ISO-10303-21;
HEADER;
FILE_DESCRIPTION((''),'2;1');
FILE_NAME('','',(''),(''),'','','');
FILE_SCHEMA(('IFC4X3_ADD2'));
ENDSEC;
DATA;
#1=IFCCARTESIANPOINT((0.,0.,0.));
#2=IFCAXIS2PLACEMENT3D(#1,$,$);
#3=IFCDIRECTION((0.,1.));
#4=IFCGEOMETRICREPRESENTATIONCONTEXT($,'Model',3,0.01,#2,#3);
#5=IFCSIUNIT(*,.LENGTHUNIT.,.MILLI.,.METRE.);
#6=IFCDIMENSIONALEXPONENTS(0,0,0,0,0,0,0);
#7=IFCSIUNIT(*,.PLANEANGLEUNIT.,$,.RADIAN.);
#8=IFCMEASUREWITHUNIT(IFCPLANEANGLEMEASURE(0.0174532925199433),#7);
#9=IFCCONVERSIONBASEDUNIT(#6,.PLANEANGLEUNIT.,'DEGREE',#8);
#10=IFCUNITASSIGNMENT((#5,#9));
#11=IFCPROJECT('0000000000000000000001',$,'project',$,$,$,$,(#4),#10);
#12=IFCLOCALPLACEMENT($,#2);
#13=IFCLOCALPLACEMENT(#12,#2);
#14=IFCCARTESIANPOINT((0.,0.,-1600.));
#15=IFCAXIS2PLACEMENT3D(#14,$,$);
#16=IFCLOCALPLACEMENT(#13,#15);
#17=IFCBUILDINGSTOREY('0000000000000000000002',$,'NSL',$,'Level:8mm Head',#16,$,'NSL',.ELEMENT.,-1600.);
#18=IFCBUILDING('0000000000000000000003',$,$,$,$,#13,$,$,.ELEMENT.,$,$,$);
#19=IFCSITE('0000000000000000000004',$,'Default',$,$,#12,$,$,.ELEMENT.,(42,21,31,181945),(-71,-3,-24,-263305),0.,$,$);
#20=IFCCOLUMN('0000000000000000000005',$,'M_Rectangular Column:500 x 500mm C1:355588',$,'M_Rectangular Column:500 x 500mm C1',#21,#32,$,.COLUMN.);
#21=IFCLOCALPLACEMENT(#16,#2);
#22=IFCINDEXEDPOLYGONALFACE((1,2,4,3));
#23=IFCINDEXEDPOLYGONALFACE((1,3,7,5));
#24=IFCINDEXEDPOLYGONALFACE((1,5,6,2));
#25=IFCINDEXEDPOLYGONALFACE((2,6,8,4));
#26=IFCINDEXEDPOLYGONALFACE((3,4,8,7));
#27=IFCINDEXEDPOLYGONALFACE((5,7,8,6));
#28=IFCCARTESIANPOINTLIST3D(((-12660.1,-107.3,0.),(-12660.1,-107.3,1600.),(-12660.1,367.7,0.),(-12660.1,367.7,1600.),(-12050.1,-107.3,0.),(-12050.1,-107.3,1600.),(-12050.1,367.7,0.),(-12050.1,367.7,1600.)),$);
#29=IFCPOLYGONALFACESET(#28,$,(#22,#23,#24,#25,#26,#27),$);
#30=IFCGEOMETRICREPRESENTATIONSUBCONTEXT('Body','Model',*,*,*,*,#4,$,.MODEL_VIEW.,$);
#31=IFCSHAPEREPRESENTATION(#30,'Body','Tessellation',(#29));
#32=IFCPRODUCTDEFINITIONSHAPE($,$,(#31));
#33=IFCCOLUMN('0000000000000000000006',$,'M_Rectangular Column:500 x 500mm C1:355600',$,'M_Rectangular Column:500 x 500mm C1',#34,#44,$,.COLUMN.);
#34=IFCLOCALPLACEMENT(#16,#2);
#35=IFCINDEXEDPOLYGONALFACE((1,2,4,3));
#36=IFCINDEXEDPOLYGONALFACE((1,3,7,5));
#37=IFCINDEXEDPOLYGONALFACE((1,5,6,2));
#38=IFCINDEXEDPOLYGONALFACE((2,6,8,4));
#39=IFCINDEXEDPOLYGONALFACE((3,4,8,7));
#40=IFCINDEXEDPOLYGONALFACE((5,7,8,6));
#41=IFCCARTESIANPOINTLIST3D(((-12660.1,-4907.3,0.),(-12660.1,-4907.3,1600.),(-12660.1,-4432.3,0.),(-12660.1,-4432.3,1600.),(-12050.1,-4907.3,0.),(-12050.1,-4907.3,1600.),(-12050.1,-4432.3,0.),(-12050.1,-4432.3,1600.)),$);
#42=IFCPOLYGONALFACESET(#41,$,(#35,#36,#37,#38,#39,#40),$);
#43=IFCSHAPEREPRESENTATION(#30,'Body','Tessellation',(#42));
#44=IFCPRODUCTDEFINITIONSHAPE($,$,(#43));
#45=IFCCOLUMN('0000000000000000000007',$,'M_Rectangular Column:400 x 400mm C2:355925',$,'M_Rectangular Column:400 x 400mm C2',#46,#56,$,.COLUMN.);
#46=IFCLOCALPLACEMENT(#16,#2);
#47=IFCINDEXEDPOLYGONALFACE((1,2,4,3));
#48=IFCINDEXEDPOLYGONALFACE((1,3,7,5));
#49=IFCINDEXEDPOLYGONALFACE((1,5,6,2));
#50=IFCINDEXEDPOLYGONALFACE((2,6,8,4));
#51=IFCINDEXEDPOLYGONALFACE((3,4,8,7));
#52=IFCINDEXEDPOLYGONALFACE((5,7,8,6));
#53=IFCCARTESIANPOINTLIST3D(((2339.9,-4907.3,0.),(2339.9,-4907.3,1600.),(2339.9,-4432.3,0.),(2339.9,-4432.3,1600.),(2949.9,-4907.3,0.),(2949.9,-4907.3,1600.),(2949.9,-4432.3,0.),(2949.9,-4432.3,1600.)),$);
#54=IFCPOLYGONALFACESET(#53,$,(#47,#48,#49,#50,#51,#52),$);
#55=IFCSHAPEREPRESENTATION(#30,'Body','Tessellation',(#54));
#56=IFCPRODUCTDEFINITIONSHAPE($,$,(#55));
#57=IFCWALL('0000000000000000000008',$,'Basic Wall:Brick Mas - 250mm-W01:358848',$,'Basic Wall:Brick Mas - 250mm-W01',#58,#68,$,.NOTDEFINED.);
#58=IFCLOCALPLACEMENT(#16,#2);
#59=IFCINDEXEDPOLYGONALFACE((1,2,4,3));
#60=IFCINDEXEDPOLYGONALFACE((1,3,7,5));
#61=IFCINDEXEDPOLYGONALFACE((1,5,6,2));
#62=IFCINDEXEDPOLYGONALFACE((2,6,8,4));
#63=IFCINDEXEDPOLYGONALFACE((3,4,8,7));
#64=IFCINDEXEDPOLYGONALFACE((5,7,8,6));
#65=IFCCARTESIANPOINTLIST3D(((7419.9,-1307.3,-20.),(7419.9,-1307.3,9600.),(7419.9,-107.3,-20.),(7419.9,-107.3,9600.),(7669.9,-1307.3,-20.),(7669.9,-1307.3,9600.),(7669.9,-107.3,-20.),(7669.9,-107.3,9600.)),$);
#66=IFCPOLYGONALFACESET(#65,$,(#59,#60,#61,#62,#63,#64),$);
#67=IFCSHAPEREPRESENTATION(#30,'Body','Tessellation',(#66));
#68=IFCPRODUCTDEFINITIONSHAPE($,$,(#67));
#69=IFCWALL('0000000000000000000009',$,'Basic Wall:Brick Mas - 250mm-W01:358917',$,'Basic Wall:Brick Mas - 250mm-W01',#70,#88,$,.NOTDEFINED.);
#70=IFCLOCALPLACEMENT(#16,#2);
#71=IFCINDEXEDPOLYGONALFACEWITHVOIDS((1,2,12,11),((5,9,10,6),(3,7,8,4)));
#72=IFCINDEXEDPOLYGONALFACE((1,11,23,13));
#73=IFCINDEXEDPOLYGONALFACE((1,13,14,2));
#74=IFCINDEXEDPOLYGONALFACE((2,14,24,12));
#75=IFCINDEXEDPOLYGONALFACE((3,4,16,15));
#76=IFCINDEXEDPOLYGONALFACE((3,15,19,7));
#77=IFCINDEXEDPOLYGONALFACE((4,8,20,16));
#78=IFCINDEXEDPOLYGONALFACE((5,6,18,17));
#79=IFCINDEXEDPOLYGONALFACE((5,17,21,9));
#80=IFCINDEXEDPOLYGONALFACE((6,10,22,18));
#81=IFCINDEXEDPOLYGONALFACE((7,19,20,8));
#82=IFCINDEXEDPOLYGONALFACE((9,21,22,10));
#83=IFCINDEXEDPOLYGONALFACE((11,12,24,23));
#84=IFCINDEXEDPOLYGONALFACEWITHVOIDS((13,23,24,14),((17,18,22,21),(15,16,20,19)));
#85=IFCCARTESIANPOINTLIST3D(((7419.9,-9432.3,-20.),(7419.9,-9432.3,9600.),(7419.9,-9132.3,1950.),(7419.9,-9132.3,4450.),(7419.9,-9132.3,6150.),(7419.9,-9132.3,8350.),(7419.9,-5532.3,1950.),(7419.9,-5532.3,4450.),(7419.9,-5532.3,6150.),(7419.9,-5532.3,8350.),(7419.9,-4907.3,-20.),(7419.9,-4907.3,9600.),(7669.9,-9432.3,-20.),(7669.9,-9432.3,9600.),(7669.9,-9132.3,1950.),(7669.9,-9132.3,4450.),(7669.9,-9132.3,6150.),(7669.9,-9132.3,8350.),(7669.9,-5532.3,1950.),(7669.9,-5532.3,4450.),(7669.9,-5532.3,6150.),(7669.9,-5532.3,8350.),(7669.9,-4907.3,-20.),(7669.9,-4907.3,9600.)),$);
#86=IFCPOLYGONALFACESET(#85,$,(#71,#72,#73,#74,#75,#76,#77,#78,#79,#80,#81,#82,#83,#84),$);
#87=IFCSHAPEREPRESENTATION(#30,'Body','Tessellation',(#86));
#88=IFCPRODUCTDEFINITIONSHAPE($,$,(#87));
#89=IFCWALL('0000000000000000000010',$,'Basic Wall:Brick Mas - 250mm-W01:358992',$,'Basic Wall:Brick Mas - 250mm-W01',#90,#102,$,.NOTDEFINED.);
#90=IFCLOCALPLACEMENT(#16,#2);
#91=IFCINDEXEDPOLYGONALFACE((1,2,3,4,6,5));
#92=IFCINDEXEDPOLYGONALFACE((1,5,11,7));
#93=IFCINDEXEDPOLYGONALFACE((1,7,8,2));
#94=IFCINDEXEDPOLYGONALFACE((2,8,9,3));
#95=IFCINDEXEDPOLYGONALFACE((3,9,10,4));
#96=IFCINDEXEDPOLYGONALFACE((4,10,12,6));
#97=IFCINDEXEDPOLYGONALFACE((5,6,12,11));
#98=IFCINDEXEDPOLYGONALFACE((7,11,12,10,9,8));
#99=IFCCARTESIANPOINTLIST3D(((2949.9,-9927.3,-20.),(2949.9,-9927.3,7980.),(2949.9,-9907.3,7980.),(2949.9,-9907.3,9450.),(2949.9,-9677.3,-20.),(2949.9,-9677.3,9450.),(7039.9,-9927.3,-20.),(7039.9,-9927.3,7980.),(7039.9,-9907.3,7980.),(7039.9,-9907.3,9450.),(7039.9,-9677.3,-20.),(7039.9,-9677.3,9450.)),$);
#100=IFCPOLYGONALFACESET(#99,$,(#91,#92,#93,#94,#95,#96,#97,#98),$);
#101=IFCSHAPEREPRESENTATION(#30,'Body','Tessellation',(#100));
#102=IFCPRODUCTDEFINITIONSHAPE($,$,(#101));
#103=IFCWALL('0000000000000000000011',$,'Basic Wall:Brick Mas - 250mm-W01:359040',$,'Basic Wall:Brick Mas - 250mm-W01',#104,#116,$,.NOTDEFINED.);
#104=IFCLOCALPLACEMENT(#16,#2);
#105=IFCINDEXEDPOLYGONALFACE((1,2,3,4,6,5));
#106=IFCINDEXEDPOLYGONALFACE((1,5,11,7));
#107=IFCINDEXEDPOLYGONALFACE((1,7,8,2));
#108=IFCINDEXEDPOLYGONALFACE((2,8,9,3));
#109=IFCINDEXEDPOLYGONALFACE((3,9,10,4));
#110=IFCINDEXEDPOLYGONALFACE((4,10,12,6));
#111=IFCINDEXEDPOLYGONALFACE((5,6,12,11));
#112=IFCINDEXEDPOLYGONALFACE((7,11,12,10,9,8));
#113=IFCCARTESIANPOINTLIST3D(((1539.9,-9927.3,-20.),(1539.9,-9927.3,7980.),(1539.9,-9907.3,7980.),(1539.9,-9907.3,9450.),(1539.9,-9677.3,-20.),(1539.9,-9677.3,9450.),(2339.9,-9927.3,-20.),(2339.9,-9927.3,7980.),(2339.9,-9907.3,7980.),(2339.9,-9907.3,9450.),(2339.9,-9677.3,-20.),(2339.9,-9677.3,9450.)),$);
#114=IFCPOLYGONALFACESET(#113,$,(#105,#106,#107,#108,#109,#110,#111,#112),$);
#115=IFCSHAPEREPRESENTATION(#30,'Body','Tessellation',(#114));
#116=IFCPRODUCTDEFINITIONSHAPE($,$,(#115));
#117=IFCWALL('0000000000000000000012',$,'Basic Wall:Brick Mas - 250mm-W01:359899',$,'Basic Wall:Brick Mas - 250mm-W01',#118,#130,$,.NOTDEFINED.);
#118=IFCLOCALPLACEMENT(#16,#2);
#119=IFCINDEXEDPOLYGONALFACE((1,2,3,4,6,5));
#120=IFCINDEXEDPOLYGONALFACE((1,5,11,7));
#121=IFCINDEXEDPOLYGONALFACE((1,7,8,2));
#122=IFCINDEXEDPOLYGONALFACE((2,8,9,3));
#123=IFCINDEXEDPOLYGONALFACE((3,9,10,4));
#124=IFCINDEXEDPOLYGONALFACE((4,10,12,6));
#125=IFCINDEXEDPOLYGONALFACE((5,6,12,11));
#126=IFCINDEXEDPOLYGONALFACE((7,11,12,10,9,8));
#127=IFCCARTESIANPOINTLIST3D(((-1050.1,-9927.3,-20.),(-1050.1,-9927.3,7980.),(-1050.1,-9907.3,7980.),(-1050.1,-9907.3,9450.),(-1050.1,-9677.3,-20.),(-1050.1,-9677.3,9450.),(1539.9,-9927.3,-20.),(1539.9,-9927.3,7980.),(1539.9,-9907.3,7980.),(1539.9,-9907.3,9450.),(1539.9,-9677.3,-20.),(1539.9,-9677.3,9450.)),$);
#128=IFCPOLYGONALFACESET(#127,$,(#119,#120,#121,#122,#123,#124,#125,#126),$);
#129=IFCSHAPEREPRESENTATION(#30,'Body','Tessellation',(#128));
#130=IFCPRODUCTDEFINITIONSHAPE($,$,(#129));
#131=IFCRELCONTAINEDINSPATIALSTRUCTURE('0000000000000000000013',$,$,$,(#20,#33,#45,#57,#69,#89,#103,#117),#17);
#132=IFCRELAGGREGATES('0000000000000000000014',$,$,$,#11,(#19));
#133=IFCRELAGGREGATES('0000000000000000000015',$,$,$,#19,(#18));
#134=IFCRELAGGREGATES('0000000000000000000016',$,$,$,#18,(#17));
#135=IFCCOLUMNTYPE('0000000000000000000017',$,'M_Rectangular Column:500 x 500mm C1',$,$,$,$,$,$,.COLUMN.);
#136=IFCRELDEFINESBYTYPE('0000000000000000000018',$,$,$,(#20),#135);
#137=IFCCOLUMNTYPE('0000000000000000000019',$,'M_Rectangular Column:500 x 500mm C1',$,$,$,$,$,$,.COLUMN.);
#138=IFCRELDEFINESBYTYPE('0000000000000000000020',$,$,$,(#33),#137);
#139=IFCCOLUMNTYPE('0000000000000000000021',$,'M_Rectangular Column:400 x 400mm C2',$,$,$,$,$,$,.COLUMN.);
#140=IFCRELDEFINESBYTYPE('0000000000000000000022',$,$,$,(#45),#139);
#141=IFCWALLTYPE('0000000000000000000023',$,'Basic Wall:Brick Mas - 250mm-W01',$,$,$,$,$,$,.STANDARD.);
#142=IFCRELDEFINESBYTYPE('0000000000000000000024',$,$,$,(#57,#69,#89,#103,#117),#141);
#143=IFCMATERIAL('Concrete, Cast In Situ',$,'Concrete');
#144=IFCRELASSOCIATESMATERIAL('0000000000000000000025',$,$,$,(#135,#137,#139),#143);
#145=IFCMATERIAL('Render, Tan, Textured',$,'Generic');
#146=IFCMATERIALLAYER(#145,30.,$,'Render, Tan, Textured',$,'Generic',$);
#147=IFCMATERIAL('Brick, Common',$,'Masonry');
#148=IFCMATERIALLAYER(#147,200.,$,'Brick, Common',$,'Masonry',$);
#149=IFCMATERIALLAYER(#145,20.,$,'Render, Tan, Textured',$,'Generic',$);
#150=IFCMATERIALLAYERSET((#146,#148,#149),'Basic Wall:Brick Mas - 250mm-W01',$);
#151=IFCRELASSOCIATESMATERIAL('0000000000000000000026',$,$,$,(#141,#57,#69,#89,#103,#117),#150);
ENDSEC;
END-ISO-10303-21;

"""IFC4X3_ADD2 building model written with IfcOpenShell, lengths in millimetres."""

from ifc_helpers import new_model, entity, si_unit, converted_unit, direction, frame, frame_2d, origin, origin_2d_with_axis, place, context, subcontext, project, spatial, polyline, rectangle, extrude, clip, bounded_halfspace, source, transform, mapped, material, layer, layer_set, material_profile, profile_set, type_object, type_shapes, element, save


model = new_model("IFC4X3_ADD2")

# Units and contexts
model_context = context("Model", 3, precision=0.01, world=origin(), true_north=direction((0.0, 1.0)))
body_context = subcontext(model_context, "Body", "Model", "MODEL_VIEW")
ifc_project = project(units=[si_unit("LENGTHUNIT", "METRE", prefix="MILLI"), converted_unit("PLANEANGLEUNIT", "DEGREE", entity("IfcPlaneAngleMeasure", 0.0174532925199433), si_unit("PLANEANGLEUNIT", "RADIAN"), dimensions=[0, 0, 0, 0, 0, 0, 0])], contexts=[model_context])

# Site, building, storey
site_placement = place(None, origin())
site = spatial("IfcSite", under=ifc_project, at=site_placement, Name="Default", CompositionType="ELEMENT", RefLatitude=(42, 21, 31, 181945), RefLongitude=(-71, -3, -24, -263305), RefElevation=0.0)
building_placement = place(site_placement, origin())
building = spatial("IfcBuilding", under=site, at=building_placement, CompositionType="ELEMENT")
storey_placement = place(building_placement, frame((0.0, 0.0, -1600.0)))
storey = spatial("IfcBuildingStorey", under=building, at=storey_placement, Name="NSL", ObjectType="Level:8mm Head", LongName="NSL", CompositionType="ELEMENT", Elevation=-1600.0)

# Columns
ifc_material_1 = material(Name="Concrete, Cast In Situ", Category="Concrete")
ifc_material_profile_1 = material_profile(ifc_material_1, rectangle(XDim=610.0, YDim=475.0, at=frame_2d((0.0, 0.0), x_axis=(1.0, 0.0))), Name="500 x 500mm C1")
ifc_profile_set_1 = profile_set([ifc_material_profile_1], Name="500 x 500mm C1")
column_type_1 = type_object("IfcColumnType", Name="M_Rectangular Column:500 x 500mm C1", PredefinedType="COLUMN", material=ifc_profile_set_1)
shared_shape_1 = source(origin(), body_context, "Body", "SweptSolid", [
    extrude(rectangle(XDim=610.0, YDim=475.0, at=origin_2d_with_axis()), frame((-12355.1, 130.2, -1600.0), z_axis=(0.0, 0.0, 1.0), x_axis=(-1.0, 0.0, 0.0)), (0.0, 0.0, 1.0), 1600.0),
])
type_shapes(column_type_1, [shared_shape_1])
column_1_placement = place(storey_placement, frame((0.0, 0.0, 1600.0)))
element("IfcColumn", 1, at=column_1_placement, inside=storey, type_object=column_type_1, Name="M_Rectangular Column:500 x 500mm C1:355588", ObjectType="M_Rectangular Column:500 x 500mm C1", PredefinedType="COLUMN", context=body_context, shape_type="MappedRepresentation", body=[
    mapped(shared_shape_1, transform((0.0, 0.0, 0.0), scale=1.0)),
])
column_type_2 = type_object("IfcColumnType", Name="M_Rectangular Column:500 x 500mm C1", PredefinedType="COLUMN", material=ifc_profile_set_1)
shared_shape_2 = source(origin(), body_context, "Body", "SweptSolid", [
    extrude(rectangle(XDim=610.0, YDim=475.0, at=frame_2d((0.0, 0.0), x_axis=(1.0, 0.0))), frame((-12355.1, -4669.8, -1600.0), z_axis=(0.0, 0.0, 1.0), x_axis=(-1.0, 0.0, 0.0)), (0.0, 0.0, 1.0), 1600.0),
])
type_shapes(column_type_2, [shared_shape_2])
column_2_placement = place(storey_placement, frame((0.0, 0.0, 1600.0)))
element("IfcColumn", 2, at=column_2_placement, inside=storey, type_object=column_type_2, Name="M_Rectangular Column:500 x 500mm C1:355600", ObjectType="M_Rectangular Column:500 x 500mm C1", PredefinedType="COLUMN", context=body_context, shape_type="MappedRepresentation", body=[
    mapped(shared_shape_2, transform((0.0, 0.0, 0.0), scale=1.0)),
])
ifc_material_profile_2 = material_profile(ifc_material_1, rectangle(XDim=610.0, YDim=475.0, at=origin_2d_with_axis()), Name="400 x 400mm C2")
ifc_profile_set_2 = profile_set([ifc_material_profile_2], Name="400 x 400mm C2")
column_type_3 = type_object("IfcColumnType", Name="M_Rectangular Column:400 x 400mm C2", PredefinedType="COLUMN", material=ifc_profile_set_2)
shared_shape_3 = source(origin(), body_context, "Body", "SweptSolid", [
    extrude(rectangle(XDim=610.0, YDim=475.0, at=origin_2d_with_axis()), frame((0.0, 0.0, -1600.0), z_axis=(0.0, 0.0, 1.0), x_axis=(-1.0, 0.0, 0.0)), (0.0, 0.0, 1.0), 1600.0),
])
type_shapes(column_type_3, [shared_shape_3])
column_3_placement = place(storey_placement, frame((2644.9, -4669.8, 1600.0)))
element("IfcColumn", 3, at=column_3_placement, inside=storey, type_object=column_type_3, Name="M_Rectangular Column:400 x 400mm C2:355925", ObjectType="M_Rectangular Column:400 x 400mm C2", PredefinedType="COLUMN", context=body_context, shape_type="MappedRepresentation", body=[
    mapped(shared_shape_3, transform((0.0, 0.0, 0.0), scale=1.0)),
])

# Wall
ifc_material_2 = material(Name="Render, Tan, Textured", Category="Generic")
ifc_layer_1 = layer(ifc_material_2, 30.0, Name="Render, Tan, Textured", Category="Generic")
ifc_material_3 = material(Name="Brick, Common", Category="Masonry")
ifc_layer_2 = layer(ifc_material_3, 200.0, Name="Brick, Common", Category="Masonry")
ifc_layer_3 = layer(ifc_material_2, 20.0, Name="Render, Tan, Textured", Category="Generic")
ifc_layer_set = layer_set([ifc_layer_1, ifc_layer_2, ifc_layer_3], Name="Basic Wall:Brick Mas - 250mm-W01")
wall_type = type_object("IfcWallType", Name="Basic Wall:Brick Mas - 250mm-W01", PredefinedType="STANDARD", material=ifc_layer_set)
wall_1_placement = place(storey_placement, frame((7544.9, -107.3, -20.0), z_axis=(0.0, 0.0, 1.0), x_axis=(0.0, -1.0, 0.0)))
element("IfcWall", 4, at=wall_1_placement, inside=storey, type_object=wall_type, material=ifc_layer_set, Name="Basic Wall:Brick Mas - 250mm-W01:358848", ObjectType="Basic Wall:Brick Mas - 250mm-W01", PredefinedType="NOTDEFINED", context=body_context, shape_type="SweptSolid", body=[
    extrude(rectangle(XDim=1200.0, YDim=250.0, at=frame_2d((600.0, 0.0), x_axis=(-1.0, 0.0))), origin(), (0.0, 0.0, 1.0), 9620.0),
])

# Wall, openings
wall_2_placement = place(storey_placement, frame((7544.9, -4907.3, -20.0), z_axis=(0.0, 0.0, 1.0), x_axis=(0.0, -1.0, 0.0)))
wall_2 = element("IfcWall", 5, at=wall_2_placement, inside=storey, type_object=wall_type, material=ifc_layer_set, Name="Basic Wall:Brick Mas - 250mm-W01:358917", ObjectType="Basic Wall:Brick Mas - 250mm-W01", PredefinedType="NOTDEFINED", context=body_context, shape_type="SweptSolid", body=[
    extrude(rectangle(XDim=4525.0, YDim=250.0, at=frame_2d((2262.5, 0.0), x_axis=(-1.0, 0.0))), origin(), (0.0, 0.0, 1.0), 9620.0),
])
opening_1_placement = place(wall_2_placement, origin())
element("IfcOpeningElement", 6, at=opening_1_placement, cuts=wall_2, PredefinedType="OPENING", context=body_context, shape_type="SweptSolid", body=[
    extrude(rectangle(XDim=2500.0, YDim=3600.0, at=frame_2d((0.0, 0.0), x_axis=(0.0, 1.0))), frame((2425.0, 125.0, 3220.0), z_axis=(0.0, -1.0, 0.0), x_axis=(-1.0, 0.0, 0.0)), (0.0, 0.0, 1.0), 250.0),
])
opening_2_placement = place(wall_2_placement, origin())
element("IfcOpeningElement", 7, at=opening_2_placement, cuts=wall_2, PredefinedType="OPENING", context=body_context, shape_type="SweptSolid", body=[
    extrude(rectangle(XDim=2200.0, YDim=3600.0, at=frame_2d((0.0, 0.0), x_axis=(0.0, 1.0))), frame((2425.0, 125.0, 7270.0), z_axis=(0.0, -1.0, 0.0), x_axis=(-1.0, 0.0, 0.0)), (0.0, 0.0, 1.0), 250.0),
])

# Walls
wall_3_placement = place(storey_placement, frame((7039.9, -9802.3, -20.0), z_axis=(0.0, 0.0, 1.0), x_axis=(-1.0, 0.0, 0.0)))
element("IfcWall", 8, at=wall_3_placement, inside=storey, type_object=wall_type, material=ifc_layer_set, Name="Basic Wall:Brick Mas - 250mm-W01:358992", ObjectType="Basic Wall:Brick Mas - 250mm-W01", PredefinedType="NOTDEFINED", context=body_context, shape_type="Clipping", body=[
    clip(clip(extrude(rectangle(XDim=4090.0, YDim=250.0, at=frame_2d((2045.0, 0.0), x_axis=(-1.0, 0.0))), origin(), (0.0, 0.0, 1.0), 9470.0), bounded_halfspace(frame((0.0, -125.0, 9470.0), z_axis=(0.0, 0.0, -1.0), x_axis=(0.0, 1.0, 0.0)), True, frame((0.0, -125.0, 9470.0)), polyline([(0.0, 0.0), (4090.0, 0.0), (4090.0, 230.0), (0.0, 230.0), (0.0, 0.0)]))), bounded_halfspace(frame((4090.0, 105.0, 8000.0), z_axis=(0.0, 0.0, 1.0), x_axis=(0.0, 1.0, 0.0)), False, frame((4090.0, 105.0, 8000.0)), polyline([(0.0, 0.0), (0.0, 20.0), (-4090.0, 20.0), (-4090.0, 0.0), (0.0, 0.0)]))),
])
wall_4_placement = place(storey_placement, frame((2339.9, -9802.3, -20.0), z_axis=(0.0, 0.0, 1.0), x_axis=(-1.0, 0.0, 0.0)))
element("IfcWall", 9, at=wall_4_placement, inside=storey, type_object=wall_type, material=ifc_layer_set, Name="Basic Wall:Brick Mas - 250mm-W01:359040", ObjectType="Basic Wall:Brick Mas - 250mm-W01", PredefinedType="NOTDEFINED", context=body_context, shape_type="Clipping", body=[
    clip(clip(extrude(rectangle(XDim=800.0, YDim=250.0, at=frame_2d((400.0, 0.0), x_axis=(-1.0, 0.0))), origin(), (0.0, 0.0, 1.0), 9470.0), bounded_halfspace(frame((0.0, -125.0, 9470.0), z_axis=(0.0, 0.0, -1.0), x_axis=(0.0, 1.0, 0.0)), True, frame((0.0, -125.0, 9470.0)), polyline([(0.0, 0.0), (800.0, 0.0), (800.0, 230.0), (0.0, 230.0), (0.0, 0.0)]))), bounded_halfspace(frame((800.0, 105.0, 8000.0), z_axis=(0.0, 0.0, 1.0), x_axis=(0.0, 1.0, 0.0)), False, frame((800.0, 105.0, 8000.0)), polyline([(0.0, 0.0), (0.0, 20.0), (-800.0, 20.0), (-800.0, 0.0), (0.0, 0.0)]))),
])
wall_5_placement = place(storey_placement, frame((1539.9, -9802.3, -20.0), z_axis=(0.0, 0.0, 1.0), x_axis=(-1.0, 0.0, 0.0)))
element("IfcWall", 10, at=wall_5_placement, inside=storey, type_object=wall_type, material=ifc_layer_set, Name="Basic Wall:Brick Mas - 250mm-W01:359899", ObjectType="Basic Wall:Brick Mas - 250mm-W01", PredefinedType="NOTDEFINED", context=body_context, shape_type="Clipping", body=[
    clip(clip(extrude(rectangle(XDim=2590.0, YDim=250.0, at=frame_2d((1295.0, 0.0), x_axis=(-1.0, 0.0))), origin(), (0.0, 0.0, 1.0), 9470.0), bounded_halfspace(frame((0.0, -125.0, 9470.0), z_axis=(0.0, 0.0, -1.0), x_axis=(0.0, 1.0, 0.0)), True, frame((0.0, -125.0, 9470.0)), polyline([(0.0, 0.0), (2590.0, 0.0), (2590.0, 230.0), (0.0, 230.0), (0.0, 0.0)]))), bounded_halfspace(frame((2590.0, 105.0, 8000.0), z_axis=(0.0, 0.0, 1.0), x_axis=(0.0, 1.0, 0.0)), False, frame((2590.0, 105.0, 8000.0)), polyline([(0.0, 0.0), (0.0, 20.0), (-2590.0, 20.0), (-2590.0, 0.0), (0.0, 0.0)]))),
])

save(model, "model.ifc")
